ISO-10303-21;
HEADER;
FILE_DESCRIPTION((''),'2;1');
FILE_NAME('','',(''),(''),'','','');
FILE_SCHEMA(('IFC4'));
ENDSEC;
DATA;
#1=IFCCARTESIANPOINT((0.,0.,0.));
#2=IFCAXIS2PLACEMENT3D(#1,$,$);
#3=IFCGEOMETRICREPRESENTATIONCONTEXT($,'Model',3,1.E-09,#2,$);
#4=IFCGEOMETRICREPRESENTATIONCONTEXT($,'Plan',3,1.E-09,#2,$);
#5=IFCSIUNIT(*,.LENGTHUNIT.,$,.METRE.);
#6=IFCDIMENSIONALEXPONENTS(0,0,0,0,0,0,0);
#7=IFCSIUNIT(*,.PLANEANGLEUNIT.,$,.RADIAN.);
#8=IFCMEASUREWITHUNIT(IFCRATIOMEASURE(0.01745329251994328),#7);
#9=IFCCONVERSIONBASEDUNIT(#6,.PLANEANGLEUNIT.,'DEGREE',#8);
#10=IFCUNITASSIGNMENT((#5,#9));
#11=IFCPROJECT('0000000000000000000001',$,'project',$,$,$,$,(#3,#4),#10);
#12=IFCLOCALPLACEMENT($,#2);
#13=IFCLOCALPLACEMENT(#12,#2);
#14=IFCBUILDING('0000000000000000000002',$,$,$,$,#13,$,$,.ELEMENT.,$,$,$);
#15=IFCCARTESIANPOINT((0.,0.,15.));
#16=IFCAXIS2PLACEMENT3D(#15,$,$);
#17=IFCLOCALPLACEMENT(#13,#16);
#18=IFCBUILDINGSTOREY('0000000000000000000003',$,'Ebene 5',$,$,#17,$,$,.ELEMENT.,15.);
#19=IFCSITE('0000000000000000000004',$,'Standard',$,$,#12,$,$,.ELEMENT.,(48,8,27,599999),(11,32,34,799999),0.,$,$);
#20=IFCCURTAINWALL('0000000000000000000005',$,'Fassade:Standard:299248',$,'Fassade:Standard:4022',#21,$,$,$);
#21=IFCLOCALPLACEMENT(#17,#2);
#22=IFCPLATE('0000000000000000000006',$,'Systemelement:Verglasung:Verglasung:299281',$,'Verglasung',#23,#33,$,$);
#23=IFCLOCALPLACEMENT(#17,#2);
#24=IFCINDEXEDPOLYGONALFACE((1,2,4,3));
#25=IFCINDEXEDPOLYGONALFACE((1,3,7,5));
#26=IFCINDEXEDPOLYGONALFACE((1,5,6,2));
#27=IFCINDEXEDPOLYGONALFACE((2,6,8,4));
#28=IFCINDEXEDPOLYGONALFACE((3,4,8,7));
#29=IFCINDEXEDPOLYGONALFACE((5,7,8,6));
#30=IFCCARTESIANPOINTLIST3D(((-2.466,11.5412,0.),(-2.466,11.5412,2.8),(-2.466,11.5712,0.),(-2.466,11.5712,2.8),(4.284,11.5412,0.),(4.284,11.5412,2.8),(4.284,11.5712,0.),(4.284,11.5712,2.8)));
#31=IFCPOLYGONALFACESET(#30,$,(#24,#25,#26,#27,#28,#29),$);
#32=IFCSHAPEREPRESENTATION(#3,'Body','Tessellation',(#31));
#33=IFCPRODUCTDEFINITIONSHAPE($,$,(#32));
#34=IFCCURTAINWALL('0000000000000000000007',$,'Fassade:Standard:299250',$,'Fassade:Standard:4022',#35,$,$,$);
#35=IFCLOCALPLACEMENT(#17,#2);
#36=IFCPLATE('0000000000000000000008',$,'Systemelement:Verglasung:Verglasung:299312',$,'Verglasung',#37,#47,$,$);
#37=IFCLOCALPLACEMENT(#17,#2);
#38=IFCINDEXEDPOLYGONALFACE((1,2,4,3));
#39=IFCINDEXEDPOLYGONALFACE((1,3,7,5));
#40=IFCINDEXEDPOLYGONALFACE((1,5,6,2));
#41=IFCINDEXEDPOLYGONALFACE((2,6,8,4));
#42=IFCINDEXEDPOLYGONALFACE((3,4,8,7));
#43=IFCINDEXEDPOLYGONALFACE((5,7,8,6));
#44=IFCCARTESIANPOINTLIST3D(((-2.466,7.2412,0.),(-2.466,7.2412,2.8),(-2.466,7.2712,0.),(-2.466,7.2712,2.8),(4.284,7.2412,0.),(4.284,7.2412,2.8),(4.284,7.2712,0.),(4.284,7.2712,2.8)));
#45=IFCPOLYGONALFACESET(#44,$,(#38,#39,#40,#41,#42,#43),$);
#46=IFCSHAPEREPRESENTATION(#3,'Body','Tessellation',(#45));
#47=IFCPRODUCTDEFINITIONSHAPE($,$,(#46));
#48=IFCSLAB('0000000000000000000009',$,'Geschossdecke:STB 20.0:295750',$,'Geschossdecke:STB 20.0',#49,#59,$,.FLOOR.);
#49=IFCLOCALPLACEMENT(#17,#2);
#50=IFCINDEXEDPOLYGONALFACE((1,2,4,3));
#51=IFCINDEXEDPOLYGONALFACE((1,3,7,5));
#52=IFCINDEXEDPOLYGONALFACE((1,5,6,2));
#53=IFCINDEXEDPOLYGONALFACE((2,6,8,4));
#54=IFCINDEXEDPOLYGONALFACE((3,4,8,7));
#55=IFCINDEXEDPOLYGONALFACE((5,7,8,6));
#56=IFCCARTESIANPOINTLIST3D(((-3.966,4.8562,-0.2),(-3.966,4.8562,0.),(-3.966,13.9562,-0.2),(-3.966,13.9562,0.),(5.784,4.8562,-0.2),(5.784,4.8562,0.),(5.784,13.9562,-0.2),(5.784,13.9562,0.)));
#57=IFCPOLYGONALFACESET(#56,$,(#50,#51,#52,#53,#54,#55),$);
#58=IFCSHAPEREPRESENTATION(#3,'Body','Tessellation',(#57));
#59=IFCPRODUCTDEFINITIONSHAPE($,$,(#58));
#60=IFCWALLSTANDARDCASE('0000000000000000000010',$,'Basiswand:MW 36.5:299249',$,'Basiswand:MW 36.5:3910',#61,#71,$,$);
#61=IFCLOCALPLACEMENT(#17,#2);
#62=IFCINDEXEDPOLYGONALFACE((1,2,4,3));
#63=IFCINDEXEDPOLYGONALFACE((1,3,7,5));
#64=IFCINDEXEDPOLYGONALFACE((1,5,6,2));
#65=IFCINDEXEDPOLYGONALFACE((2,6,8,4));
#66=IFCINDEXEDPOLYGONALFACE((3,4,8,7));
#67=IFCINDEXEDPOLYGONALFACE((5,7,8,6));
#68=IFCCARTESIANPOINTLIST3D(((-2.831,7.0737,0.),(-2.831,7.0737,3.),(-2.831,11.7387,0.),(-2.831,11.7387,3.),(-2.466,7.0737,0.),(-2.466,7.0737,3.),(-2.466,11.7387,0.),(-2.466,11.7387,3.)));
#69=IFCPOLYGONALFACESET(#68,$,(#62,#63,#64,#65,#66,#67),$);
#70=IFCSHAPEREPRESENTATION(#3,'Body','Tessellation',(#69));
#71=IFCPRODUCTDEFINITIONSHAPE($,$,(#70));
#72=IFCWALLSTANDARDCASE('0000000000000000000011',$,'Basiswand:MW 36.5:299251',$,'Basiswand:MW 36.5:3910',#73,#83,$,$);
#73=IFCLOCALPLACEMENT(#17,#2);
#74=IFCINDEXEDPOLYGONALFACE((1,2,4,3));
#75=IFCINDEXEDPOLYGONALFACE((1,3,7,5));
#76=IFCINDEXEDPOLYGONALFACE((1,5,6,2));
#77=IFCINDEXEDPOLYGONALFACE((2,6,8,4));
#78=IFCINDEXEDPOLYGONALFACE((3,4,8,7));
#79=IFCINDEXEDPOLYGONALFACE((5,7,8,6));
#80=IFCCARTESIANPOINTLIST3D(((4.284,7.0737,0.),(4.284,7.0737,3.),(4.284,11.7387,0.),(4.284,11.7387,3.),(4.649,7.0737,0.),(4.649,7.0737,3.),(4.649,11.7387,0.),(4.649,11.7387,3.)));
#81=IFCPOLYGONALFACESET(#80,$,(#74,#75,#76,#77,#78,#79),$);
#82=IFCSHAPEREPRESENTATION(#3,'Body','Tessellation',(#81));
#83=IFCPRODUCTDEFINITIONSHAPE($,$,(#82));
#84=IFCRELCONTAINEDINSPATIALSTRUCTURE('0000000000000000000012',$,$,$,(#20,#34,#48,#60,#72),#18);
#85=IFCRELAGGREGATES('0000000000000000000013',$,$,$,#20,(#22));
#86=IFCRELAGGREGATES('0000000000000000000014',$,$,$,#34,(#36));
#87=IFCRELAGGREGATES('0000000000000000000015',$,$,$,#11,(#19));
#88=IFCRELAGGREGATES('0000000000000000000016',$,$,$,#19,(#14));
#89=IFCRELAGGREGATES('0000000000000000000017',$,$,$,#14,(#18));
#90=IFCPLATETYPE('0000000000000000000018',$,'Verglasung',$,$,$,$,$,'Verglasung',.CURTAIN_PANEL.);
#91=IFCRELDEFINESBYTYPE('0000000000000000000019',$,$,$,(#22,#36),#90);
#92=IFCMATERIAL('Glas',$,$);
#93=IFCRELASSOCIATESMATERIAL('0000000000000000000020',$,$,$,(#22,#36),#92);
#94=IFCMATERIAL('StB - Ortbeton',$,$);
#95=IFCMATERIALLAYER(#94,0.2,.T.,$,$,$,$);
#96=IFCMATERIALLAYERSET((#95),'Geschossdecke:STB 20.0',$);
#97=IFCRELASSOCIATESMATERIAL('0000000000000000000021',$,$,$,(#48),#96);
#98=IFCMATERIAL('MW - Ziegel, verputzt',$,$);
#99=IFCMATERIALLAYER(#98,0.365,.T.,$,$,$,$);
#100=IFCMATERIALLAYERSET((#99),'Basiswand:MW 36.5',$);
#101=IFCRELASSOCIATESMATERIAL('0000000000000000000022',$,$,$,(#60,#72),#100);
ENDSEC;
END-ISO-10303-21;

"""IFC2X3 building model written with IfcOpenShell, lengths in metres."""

from ifc_helpers import new_model, entity, si_unit, converted_unit, frame, frame_2d, origin, origin_2d_with_axis, place, context, project, spatial, rectangle, extrude, source, transform, mapped, material, layer, layer_set, layer_usage, type_object, type_shapes, element, aggregate, save


model = new_model("IFC2X3")

# Units and contexts
model_context = context("Model", 3, precision=1e-09, world=origin())
plan_context = context("Plan", 3, precision=1e-09, world=origin())
ifc_project = project(units=[si_unit("LENGTHUNIT", "METRE"), converted_unit("PLANEANGLEUNIT", "DEGREE", entity("IfcRatioMeasure", 0.01745329251994328), si_unit("PLANEANGLEUNIT", "RADIAN"), dimensions=[0, 0, 0, 0, 0, 0, 0])], contexts=[model_context, plan_context])

# Site, building, storey
site_placement = place(None, origin())
site = spatial("IfcSite", under=ifc_project, at=site_placement, Name="Standard", CompositionType="ELEMENT", RefLatitude=(48, 8, 27, 599999), RefLongitude=(11, 32, 34, 799999), RefElevation=0.0)
building_placement = place(site_placement, origin())
building = spatial("IfcBuilding", under=site, at=building_placement, CompositionType="ELEMENT")
storey_placement = place(building_placement, frame((0.0, 0.0, 15.0)))
storey = spatial("IfcBuildingStorey", under=building, at=storey_placement, Name="Ebene 5", CompositionType="ELEMENT", Elevation=15.0)

# Curtain walls, plates
curtain_wall_1_placement = place(storey_placement, origin())
curtain_wall_1 = element("IfcCurtainWall", 1, at=curtain_wall_1_placement, inside=storey, Name="Fassade:Standard:299248", ObjectType="Fassade:Standard:4022")
ifc_material_1 = material(Name="Glas")
plate_type = type_object("IfcPlateType", Name="Verglasung", ElementType="Verglasung", PredefinedType="CURTAIN_PANEL")
shared_shape = source(origin(), model_context, "Body", "SweptSolid", [
    extrude(rectangle(XDim=0.03, YDim=6.75, at=origin_2d_with_axis()), frame((0.0, 0.0, 0.0), z_axis=(0.0, 0.0, 1.0), x_axis=(0.0, 1.0, 0.0)), (0.0, 0.0, 1.0), 2.8),
])
type_shapes(plate_type, [shared_shape])
plate_1_placement = place(storey_placement, frame((0.909, 11.5562, 0.0)))
plate_1 = element("IfcPlate", 2, at=plate_1_placement, type_object=plate_type, material=ifc_material_1, Name="Systemelement:Verglasung:Verglasung:299281", ObjectType="Verglasung", context=model_context, shape_type="MappedRepresentation", body=[
    mapped(shared_shape, transform((0.0, 0.0, 0.0), scale=1.0)),
])
aggregate(curtain_wall_1, [plate_1])
curtain_wall_2_placement = place(storey_placement, origin())
curtain_wall_2 = element("IfcCurtainWall", 3, at=curtain_wall_2_placement, inside=storey, Name="Fassade:Standard:299250", ObjectType="Fassade:Standard:4022")
plate_2_placement = place(storey_placement, frame((0.909, 7.2562, 0.0), z_axis=(0.0, 0.0, 1.0), x_axis=(-1.0, 0.0, 0.0)))
plate_2 = element("IfcPlate", 4, at=plate_2_placement, type_object=plate_type, material=ifc_material_1, Name="Systemelement:Verglasung:Verglasung:299312", ObjectType="Verglasung", context=model_context, shape_type="MappedRepresentation", body=[
    mapped(shared_shape, transform((0.0, 0.0, 0.0), scale=1.0)),
])
aggregate(curtain_wall_2, [plate_2])

# Slab
ifc_material_2 = material(Name="StB - Ortbeton")
ifc_layer_1 = layer(ifc_material_2, 0.2, ventilated=True)
ifc_layer_set_1 = layer_set([ifc_layer_1], Name="Geschossdecke:STB 20.0")
ifc_layer_usage_1 = layer_usage(ifc_layer_set_1, "AXIS3", "POSITIVE", 0.0)
slab_1_placement = place(storey_placement, frame((-3.966, 4.8562, -0.2)))
element("IfcSlab", 5, at=slab_1_placement, inside=storey, material=ifc_layer_usage_1, Name="Geschossdecke:STB 20.0:295750", ObjectType="Geschossdecke:STB 20.0", PredefinedType="FLOOR", context=model_context, shape_type="SweptSolid", body=[
    extrude(rectangle(XDim=9.1, YDim=9.75, at=frame_2d((0.0, 0.0), x_axis=(0.0, -1.0))), frame((4.875, 4.55, 0.2), z_axis=(0.0, 0.0, -1.0), x_axis=(-1.0, 0.0, 0.0)), (0.0, 0.0, 1.0), 0.2),
])

# Walls
ifc_material_3 = material(Name="MW - Ziegel, verputzt")
ifc_layer_2 = layer(ifc_material_3, 0.365, ventilated=True)
ifc_layer_set_2 = layer_set([ifc_layer_2], Name="Basiswand:MW 36.5")
ifc_layer_usage_2 = layer_usage(ifc_layer_set_2, "AXIS2", "NEGATIVE", 0.1825)
wall_1_placement = place(storey_placement, frame((-2.6485, 7.0737, 0.0), z_axis=(0.0, 0.0, 1.0), x_axis=(0.0, 1.0, 0.0)))
element("IfcWallStandardCase", 6, at=wall_1_placement, inside=storey, material=ifc_layer_usage_2, Name="Basiswand:MW 36.5:299249", ObjectType="Basiswand:MW 36.5:3910", context=model_context, shape_type="SweptSolid", body=[
    extrude(rectangle(XDim=4.665, YDim=0.365, at=frame_2d((2.3325, 0.0), x_axis=(-1.0, 0.0))), origin(), (0.0, 0.0, 1.0), 3.0),
])
ifc_layer_usage_3 = layer_usage(ifc_layer_set_2, "AXIS2", "NEGATIVE", 0.1825)
wall_2_placement = place(storey_placement, frame((4.4665, 11.7387, 0.0), z_axis=(0.0, 0.0, 1.0), x_axis=(0.0, -1.0, 0.0)))
element("IfcWallStandardCase", 7, at=wall_2_placement, inside=storey, material=ifc_layer_usage_3, Name="Basiswand:MW 36.5:299251", ObjectType="Basiswand:MW 36.5:3910", context=model_context, shape_type="SweptSolid", body=[
    extrude(rectangle(XDim=4.665, YDim=0.365, at=frame_2d((2.3325, 0.0), x_axis=(-1.0, 0.0))), origin(), (0.0, 0.0, 1.0), 3.0),
])

save(model, "model.ifc")
